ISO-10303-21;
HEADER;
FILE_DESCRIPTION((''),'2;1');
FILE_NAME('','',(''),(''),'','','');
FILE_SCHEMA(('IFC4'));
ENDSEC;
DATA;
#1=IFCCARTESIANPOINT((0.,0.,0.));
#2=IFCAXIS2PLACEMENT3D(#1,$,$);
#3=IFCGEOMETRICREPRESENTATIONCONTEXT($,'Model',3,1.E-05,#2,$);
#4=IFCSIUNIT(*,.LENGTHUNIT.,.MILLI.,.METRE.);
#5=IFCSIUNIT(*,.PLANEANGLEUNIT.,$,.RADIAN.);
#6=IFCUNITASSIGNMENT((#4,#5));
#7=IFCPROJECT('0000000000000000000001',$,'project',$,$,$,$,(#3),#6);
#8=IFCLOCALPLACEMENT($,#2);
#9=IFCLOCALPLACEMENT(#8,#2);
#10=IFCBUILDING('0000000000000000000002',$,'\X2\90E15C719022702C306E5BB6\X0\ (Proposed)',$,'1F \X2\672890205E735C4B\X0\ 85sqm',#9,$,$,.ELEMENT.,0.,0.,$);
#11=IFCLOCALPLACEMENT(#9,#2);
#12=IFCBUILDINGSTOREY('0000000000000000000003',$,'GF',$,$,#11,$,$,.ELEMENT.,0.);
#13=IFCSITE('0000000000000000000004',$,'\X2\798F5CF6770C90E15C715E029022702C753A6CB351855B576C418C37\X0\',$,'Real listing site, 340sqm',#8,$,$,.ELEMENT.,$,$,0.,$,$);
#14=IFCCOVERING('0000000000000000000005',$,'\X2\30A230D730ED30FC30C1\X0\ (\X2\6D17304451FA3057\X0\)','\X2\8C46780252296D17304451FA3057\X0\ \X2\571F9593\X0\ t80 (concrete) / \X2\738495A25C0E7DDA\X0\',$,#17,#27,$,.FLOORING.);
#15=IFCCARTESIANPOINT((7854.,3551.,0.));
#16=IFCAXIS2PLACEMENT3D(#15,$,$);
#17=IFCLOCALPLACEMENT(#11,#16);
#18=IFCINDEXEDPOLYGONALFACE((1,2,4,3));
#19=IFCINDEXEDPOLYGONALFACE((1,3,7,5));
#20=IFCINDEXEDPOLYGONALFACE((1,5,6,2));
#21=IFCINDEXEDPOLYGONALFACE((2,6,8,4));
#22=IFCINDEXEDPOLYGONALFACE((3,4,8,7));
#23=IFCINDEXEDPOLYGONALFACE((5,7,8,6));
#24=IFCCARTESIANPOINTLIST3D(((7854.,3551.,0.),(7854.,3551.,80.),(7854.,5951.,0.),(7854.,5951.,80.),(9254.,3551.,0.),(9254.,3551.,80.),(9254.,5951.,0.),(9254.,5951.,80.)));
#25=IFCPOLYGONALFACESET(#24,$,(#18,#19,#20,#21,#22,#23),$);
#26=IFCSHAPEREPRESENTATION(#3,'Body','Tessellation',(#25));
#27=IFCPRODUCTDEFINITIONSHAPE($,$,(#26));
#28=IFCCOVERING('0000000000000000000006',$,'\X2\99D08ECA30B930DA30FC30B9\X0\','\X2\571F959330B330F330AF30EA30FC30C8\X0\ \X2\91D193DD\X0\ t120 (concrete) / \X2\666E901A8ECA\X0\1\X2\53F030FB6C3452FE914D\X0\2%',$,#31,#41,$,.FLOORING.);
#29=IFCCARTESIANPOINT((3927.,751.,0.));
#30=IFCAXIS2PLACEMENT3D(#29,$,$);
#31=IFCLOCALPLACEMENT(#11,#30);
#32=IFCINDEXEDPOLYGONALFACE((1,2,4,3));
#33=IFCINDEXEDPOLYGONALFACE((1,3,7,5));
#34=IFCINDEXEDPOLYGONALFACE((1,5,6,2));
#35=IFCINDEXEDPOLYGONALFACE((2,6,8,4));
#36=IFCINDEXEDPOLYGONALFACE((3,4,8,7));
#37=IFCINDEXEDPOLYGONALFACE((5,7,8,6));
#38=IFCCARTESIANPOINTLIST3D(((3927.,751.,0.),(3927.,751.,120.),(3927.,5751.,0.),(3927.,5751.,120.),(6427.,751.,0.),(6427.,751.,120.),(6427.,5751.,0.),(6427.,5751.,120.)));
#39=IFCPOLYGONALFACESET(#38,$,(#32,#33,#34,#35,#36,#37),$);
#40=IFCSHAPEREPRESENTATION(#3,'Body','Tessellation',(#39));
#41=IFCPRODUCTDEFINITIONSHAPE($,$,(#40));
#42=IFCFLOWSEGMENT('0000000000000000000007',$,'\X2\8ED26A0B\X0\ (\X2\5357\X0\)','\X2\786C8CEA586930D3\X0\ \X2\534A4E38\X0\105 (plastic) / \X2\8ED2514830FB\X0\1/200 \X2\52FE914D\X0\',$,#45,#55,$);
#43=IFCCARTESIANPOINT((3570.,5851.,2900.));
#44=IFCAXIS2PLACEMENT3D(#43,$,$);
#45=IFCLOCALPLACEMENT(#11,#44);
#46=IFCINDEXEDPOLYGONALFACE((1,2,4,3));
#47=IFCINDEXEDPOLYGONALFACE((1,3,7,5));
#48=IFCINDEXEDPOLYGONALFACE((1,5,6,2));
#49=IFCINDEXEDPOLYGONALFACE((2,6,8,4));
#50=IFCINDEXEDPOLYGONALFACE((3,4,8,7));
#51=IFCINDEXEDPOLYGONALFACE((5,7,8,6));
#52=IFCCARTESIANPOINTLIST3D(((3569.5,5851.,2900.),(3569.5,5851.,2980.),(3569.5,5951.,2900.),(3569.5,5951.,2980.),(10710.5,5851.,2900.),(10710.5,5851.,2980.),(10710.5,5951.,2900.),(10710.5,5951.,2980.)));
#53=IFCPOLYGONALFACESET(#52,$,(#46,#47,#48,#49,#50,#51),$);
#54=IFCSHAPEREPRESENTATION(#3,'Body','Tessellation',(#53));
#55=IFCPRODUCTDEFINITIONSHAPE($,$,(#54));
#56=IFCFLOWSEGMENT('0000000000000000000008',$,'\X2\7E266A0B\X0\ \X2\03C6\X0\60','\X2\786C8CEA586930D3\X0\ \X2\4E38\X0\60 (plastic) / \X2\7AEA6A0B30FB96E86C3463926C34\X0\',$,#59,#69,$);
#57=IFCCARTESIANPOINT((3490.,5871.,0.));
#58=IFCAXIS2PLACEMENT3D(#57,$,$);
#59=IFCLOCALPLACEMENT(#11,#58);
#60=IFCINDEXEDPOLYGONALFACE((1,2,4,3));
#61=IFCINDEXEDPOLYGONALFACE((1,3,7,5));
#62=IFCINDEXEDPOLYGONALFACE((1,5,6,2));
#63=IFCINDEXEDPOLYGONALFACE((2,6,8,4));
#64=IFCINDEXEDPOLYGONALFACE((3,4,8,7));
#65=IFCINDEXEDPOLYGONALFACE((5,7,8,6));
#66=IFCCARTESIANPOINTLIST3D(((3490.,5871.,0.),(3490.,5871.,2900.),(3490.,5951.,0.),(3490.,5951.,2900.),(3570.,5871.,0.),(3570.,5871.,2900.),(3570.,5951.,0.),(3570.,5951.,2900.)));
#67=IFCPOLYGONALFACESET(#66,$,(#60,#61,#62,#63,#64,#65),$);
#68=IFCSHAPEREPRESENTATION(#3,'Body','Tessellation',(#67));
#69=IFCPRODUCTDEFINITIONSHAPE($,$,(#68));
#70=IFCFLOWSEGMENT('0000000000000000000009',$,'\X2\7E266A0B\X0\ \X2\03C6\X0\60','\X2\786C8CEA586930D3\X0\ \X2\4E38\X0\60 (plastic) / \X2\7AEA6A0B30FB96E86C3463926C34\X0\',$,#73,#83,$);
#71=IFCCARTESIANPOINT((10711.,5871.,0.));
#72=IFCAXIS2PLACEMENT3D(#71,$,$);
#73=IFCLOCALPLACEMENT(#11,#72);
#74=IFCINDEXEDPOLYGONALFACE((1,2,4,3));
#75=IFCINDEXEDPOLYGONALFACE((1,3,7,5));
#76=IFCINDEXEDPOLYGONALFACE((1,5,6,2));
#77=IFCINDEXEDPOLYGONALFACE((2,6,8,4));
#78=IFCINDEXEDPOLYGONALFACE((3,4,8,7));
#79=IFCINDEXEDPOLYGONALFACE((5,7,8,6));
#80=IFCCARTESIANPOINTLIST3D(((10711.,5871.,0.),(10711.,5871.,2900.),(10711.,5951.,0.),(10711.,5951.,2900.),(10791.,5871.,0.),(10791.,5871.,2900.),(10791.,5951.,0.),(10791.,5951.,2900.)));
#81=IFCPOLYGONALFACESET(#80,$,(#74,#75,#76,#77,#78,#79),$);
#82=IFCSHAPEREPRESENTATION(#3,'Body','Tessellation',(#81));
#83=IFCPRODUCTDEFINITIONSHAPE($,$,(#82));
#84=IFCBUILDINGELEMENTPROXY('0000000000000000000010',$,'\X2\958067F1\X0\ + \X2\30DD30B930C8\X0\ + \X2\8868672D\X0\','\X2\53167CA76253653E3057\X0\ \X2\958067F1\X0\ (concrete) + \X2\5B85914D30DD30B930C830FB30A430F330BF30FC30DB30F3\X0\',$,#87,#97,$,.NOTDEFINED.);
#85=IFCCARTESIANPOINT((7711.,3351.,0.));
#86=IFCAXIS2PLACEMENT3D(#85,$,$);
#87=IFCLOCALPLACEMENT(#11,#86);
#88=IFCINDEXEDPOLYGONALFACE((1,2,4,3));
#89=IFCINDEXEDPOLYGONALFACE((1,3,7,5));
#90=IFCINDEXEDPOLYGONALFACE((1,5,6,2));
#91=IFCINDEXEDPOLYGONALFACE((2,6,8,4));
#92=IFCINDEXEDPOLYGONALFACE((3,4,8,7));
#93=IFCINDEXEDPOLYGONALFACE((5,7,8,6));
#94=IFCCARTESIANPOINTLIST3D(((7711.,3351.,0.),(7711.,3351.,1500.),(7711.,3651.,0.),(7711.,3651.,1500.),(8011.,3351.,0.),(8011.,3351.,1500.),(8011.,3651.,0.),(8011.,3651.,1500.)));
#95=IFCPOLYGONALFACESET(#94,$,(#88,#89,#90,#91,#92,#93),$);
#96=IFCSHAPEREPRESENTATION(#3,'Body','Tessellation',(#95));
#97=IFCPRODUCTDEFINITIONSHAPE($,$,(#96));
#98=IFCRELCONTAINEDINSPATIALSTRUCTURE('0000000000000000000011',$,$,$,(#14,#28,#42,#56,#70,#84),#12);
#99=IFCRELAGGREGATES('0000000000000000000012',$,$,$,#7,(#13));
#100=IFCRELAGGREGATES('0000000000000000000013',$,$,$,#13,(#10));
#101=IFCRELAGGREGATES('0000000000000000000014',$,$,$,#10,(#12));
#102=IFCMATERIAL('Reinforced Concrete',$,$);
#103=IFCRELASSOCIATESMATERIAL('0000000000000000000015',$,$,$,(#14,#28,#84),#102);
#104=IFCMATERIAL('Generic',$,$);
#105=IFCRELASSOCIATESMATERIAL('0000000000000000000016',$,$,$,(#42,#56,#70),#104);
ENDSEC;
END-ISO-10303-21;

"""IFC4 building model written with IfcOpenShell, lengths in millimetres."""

from ifc_helpers import new_model, si_unit, frame, frame_2d, origin, place, context, project, spatial, rectangle, extrude, material, element, save


model = new_model("IFC4")

# Units and contexts
model_context = context("Model", 3, precision=1e-05, world=origin())
ifc_project = project(units=[si_unit("LENGTHUNIT", "METRE", prefix="MILLI"), si_unit("PLANEANGLEUNIT", "RADIAN")], contexts=[model_context])

# Site, building, storey
site_placement = place(None, origin())
site = spatial("IfcSite", under=ifc_project, at=site_placement, Name="福島県郡山市逢瀬町河内字汁谷", ObjectType="Real listing site, 340sqm", CompositionType="ELEMENT", RefElevation=0.0)
building_placement = place(site_placement, origin())
building = spatial("IfcBuilding", under=site, at=building_placement, Name="郡山逢瀬の家 (Proposed)", ObjectType="1F 木造平屋 85sqm", CompositionType="ELEMENT", ElevationOfRefHeight=0.0, ElevationOfTerrain=0.0)
storey_placement = place(building_placement, origin())
storey = spatial("IfcBuildingStorey", under=building, at=storey_placement, Name="GF", CompositionType="ELEMENT", Elevation=0.0)

# Shared definitions
ifc_material_1 = material(Name="Reinforced Concrete")

# Coverings
covering_1_placement = place(storey_placement, frame((7854.0, 3551.0, 0.0)))
element("IfcCovering", 1, at=covering_1_placement, inside=storey, material=ifc_material_1, Name="アプローチ (洗い出し)", Description="豆砂利洗い出し 土間 t80 (concrete) / 玄関導線", PredefinedType="FLOORING", context=model_context, shape_type="SweptSolid", body=[
    extrude(rectangle(XDim=1400.0, YDim=2400.0, at=frame_2d((700.0, 1200.0))), frame((7854.0, 3551.0, 0.0)), (0.0, 0.0, 1.0), 80.0),
])
covering_2_placement = place(storey_placement, frame((3927.0, 751.0, 0.0)))
element("IfcCovering", 2, at=covering_2_placement, inside=storey, material=ifc_material_1, Name="駐車スペース", Description="土間コンクリート 金鏝 t120 (concrete) / 普通車1台・水勾配2%", PredefinedType="FLOORING", context=model_context, shape_type="SweptSolid", body=[
    extrude(rectangle(XDim=2500.0, YDim=5000.0, at=frame_2d((1250.0, 2500.0))), frame((3927.0, 751.0, 0.0)), (0.0, 0.0, 1.0), 120.0),
])

# Flow segments
ifc_material_2 = material(Name="Generic")
flow_segment_1_placement = place(storey_placement, frame((3570.0, 5851.0, 2900.0)))
element("IfcFlowSegment", 3, at=flow_segment_1_placement, inside=storey, material=ifc_material_2, Name="軒樋 (南)", Description="硬質塩ビ 半丸105 (plastic) / 軒先・1/200 勾配", context=model_context, shape_type="SweptSolid", body=[
    extrude(rectangle(XDim=7141.0, YDim=100.0, at=frame_2d((3570.0, 50.0))), frame((3570.0, 5851.0, 2900.0)), (0.0, 0.0, 1.0), 80.0),
])
flow_segment_2_placement = place(storey_placement, frame((3490.0, 5871.0, 0.0)))
element("IfcFlowSegment", 4, at=flow_segment_2_placement, inside=storey, material=ifc_material_2, Name="縦樋 φ60", Description="硬質塩ビ 丸60 (plastic) / 竪樋・雨水排水", context=model_context, shape_type="SweptSolid", body=[
    extrude(rectangle(XDim=80.0, YDim=80.0, at=frame_2d((40.0, 40.0))), frame((3490.0, 5871.0, 0.0)), (0.0, 0.0, 1.0), 2900.0),
])
flow_segment_3_placement = place(storey_placement, frame((10711.0, 5871.0, 0.0)))
element("IfcFlowSegment", 5, at=flow_segment_3_placement, inside=storey, material=ifc_material_2, Name="縦樋 φ60", Description="硬質塩ビ 丸60 (plastic) / 竪樋・雨水排水", context=model_context, shape_type="SweptSolid", body=[
    extrude(rectangle(XDim=80.0, YDim=80.0, at=frame_2d((40.0, 40.0))), frame((10711.0, 5871.0, 0.0)), (0.0, 0.0, 1.0), 2900.0),
])

# Building element proxy
proxy_placement = place(storey_placement, frame((7711.0, 3351.0, 0.0)))
element("IfcBuildingElementProxy", 6, at=proxy_placement, inside=storey, material=ifc_material_1, Name="門柱 + ポスト + 表札", Description="化粧打放し 門柱 (concrete) + 宅配ポスト・インターホン", PredefinedType="NOTDEFINED", context=model_context, shape_type="SweptSolid", body=[
    extrude(rectangle(XDim=300.0, YDim=300.0, at=frame_2d((150.0, 150.0))), frame((7711.0, 3351.0, 0.0)), (0.0, 0.0, 1.0), 1500.0),
])

save(model, "model.ifc")
